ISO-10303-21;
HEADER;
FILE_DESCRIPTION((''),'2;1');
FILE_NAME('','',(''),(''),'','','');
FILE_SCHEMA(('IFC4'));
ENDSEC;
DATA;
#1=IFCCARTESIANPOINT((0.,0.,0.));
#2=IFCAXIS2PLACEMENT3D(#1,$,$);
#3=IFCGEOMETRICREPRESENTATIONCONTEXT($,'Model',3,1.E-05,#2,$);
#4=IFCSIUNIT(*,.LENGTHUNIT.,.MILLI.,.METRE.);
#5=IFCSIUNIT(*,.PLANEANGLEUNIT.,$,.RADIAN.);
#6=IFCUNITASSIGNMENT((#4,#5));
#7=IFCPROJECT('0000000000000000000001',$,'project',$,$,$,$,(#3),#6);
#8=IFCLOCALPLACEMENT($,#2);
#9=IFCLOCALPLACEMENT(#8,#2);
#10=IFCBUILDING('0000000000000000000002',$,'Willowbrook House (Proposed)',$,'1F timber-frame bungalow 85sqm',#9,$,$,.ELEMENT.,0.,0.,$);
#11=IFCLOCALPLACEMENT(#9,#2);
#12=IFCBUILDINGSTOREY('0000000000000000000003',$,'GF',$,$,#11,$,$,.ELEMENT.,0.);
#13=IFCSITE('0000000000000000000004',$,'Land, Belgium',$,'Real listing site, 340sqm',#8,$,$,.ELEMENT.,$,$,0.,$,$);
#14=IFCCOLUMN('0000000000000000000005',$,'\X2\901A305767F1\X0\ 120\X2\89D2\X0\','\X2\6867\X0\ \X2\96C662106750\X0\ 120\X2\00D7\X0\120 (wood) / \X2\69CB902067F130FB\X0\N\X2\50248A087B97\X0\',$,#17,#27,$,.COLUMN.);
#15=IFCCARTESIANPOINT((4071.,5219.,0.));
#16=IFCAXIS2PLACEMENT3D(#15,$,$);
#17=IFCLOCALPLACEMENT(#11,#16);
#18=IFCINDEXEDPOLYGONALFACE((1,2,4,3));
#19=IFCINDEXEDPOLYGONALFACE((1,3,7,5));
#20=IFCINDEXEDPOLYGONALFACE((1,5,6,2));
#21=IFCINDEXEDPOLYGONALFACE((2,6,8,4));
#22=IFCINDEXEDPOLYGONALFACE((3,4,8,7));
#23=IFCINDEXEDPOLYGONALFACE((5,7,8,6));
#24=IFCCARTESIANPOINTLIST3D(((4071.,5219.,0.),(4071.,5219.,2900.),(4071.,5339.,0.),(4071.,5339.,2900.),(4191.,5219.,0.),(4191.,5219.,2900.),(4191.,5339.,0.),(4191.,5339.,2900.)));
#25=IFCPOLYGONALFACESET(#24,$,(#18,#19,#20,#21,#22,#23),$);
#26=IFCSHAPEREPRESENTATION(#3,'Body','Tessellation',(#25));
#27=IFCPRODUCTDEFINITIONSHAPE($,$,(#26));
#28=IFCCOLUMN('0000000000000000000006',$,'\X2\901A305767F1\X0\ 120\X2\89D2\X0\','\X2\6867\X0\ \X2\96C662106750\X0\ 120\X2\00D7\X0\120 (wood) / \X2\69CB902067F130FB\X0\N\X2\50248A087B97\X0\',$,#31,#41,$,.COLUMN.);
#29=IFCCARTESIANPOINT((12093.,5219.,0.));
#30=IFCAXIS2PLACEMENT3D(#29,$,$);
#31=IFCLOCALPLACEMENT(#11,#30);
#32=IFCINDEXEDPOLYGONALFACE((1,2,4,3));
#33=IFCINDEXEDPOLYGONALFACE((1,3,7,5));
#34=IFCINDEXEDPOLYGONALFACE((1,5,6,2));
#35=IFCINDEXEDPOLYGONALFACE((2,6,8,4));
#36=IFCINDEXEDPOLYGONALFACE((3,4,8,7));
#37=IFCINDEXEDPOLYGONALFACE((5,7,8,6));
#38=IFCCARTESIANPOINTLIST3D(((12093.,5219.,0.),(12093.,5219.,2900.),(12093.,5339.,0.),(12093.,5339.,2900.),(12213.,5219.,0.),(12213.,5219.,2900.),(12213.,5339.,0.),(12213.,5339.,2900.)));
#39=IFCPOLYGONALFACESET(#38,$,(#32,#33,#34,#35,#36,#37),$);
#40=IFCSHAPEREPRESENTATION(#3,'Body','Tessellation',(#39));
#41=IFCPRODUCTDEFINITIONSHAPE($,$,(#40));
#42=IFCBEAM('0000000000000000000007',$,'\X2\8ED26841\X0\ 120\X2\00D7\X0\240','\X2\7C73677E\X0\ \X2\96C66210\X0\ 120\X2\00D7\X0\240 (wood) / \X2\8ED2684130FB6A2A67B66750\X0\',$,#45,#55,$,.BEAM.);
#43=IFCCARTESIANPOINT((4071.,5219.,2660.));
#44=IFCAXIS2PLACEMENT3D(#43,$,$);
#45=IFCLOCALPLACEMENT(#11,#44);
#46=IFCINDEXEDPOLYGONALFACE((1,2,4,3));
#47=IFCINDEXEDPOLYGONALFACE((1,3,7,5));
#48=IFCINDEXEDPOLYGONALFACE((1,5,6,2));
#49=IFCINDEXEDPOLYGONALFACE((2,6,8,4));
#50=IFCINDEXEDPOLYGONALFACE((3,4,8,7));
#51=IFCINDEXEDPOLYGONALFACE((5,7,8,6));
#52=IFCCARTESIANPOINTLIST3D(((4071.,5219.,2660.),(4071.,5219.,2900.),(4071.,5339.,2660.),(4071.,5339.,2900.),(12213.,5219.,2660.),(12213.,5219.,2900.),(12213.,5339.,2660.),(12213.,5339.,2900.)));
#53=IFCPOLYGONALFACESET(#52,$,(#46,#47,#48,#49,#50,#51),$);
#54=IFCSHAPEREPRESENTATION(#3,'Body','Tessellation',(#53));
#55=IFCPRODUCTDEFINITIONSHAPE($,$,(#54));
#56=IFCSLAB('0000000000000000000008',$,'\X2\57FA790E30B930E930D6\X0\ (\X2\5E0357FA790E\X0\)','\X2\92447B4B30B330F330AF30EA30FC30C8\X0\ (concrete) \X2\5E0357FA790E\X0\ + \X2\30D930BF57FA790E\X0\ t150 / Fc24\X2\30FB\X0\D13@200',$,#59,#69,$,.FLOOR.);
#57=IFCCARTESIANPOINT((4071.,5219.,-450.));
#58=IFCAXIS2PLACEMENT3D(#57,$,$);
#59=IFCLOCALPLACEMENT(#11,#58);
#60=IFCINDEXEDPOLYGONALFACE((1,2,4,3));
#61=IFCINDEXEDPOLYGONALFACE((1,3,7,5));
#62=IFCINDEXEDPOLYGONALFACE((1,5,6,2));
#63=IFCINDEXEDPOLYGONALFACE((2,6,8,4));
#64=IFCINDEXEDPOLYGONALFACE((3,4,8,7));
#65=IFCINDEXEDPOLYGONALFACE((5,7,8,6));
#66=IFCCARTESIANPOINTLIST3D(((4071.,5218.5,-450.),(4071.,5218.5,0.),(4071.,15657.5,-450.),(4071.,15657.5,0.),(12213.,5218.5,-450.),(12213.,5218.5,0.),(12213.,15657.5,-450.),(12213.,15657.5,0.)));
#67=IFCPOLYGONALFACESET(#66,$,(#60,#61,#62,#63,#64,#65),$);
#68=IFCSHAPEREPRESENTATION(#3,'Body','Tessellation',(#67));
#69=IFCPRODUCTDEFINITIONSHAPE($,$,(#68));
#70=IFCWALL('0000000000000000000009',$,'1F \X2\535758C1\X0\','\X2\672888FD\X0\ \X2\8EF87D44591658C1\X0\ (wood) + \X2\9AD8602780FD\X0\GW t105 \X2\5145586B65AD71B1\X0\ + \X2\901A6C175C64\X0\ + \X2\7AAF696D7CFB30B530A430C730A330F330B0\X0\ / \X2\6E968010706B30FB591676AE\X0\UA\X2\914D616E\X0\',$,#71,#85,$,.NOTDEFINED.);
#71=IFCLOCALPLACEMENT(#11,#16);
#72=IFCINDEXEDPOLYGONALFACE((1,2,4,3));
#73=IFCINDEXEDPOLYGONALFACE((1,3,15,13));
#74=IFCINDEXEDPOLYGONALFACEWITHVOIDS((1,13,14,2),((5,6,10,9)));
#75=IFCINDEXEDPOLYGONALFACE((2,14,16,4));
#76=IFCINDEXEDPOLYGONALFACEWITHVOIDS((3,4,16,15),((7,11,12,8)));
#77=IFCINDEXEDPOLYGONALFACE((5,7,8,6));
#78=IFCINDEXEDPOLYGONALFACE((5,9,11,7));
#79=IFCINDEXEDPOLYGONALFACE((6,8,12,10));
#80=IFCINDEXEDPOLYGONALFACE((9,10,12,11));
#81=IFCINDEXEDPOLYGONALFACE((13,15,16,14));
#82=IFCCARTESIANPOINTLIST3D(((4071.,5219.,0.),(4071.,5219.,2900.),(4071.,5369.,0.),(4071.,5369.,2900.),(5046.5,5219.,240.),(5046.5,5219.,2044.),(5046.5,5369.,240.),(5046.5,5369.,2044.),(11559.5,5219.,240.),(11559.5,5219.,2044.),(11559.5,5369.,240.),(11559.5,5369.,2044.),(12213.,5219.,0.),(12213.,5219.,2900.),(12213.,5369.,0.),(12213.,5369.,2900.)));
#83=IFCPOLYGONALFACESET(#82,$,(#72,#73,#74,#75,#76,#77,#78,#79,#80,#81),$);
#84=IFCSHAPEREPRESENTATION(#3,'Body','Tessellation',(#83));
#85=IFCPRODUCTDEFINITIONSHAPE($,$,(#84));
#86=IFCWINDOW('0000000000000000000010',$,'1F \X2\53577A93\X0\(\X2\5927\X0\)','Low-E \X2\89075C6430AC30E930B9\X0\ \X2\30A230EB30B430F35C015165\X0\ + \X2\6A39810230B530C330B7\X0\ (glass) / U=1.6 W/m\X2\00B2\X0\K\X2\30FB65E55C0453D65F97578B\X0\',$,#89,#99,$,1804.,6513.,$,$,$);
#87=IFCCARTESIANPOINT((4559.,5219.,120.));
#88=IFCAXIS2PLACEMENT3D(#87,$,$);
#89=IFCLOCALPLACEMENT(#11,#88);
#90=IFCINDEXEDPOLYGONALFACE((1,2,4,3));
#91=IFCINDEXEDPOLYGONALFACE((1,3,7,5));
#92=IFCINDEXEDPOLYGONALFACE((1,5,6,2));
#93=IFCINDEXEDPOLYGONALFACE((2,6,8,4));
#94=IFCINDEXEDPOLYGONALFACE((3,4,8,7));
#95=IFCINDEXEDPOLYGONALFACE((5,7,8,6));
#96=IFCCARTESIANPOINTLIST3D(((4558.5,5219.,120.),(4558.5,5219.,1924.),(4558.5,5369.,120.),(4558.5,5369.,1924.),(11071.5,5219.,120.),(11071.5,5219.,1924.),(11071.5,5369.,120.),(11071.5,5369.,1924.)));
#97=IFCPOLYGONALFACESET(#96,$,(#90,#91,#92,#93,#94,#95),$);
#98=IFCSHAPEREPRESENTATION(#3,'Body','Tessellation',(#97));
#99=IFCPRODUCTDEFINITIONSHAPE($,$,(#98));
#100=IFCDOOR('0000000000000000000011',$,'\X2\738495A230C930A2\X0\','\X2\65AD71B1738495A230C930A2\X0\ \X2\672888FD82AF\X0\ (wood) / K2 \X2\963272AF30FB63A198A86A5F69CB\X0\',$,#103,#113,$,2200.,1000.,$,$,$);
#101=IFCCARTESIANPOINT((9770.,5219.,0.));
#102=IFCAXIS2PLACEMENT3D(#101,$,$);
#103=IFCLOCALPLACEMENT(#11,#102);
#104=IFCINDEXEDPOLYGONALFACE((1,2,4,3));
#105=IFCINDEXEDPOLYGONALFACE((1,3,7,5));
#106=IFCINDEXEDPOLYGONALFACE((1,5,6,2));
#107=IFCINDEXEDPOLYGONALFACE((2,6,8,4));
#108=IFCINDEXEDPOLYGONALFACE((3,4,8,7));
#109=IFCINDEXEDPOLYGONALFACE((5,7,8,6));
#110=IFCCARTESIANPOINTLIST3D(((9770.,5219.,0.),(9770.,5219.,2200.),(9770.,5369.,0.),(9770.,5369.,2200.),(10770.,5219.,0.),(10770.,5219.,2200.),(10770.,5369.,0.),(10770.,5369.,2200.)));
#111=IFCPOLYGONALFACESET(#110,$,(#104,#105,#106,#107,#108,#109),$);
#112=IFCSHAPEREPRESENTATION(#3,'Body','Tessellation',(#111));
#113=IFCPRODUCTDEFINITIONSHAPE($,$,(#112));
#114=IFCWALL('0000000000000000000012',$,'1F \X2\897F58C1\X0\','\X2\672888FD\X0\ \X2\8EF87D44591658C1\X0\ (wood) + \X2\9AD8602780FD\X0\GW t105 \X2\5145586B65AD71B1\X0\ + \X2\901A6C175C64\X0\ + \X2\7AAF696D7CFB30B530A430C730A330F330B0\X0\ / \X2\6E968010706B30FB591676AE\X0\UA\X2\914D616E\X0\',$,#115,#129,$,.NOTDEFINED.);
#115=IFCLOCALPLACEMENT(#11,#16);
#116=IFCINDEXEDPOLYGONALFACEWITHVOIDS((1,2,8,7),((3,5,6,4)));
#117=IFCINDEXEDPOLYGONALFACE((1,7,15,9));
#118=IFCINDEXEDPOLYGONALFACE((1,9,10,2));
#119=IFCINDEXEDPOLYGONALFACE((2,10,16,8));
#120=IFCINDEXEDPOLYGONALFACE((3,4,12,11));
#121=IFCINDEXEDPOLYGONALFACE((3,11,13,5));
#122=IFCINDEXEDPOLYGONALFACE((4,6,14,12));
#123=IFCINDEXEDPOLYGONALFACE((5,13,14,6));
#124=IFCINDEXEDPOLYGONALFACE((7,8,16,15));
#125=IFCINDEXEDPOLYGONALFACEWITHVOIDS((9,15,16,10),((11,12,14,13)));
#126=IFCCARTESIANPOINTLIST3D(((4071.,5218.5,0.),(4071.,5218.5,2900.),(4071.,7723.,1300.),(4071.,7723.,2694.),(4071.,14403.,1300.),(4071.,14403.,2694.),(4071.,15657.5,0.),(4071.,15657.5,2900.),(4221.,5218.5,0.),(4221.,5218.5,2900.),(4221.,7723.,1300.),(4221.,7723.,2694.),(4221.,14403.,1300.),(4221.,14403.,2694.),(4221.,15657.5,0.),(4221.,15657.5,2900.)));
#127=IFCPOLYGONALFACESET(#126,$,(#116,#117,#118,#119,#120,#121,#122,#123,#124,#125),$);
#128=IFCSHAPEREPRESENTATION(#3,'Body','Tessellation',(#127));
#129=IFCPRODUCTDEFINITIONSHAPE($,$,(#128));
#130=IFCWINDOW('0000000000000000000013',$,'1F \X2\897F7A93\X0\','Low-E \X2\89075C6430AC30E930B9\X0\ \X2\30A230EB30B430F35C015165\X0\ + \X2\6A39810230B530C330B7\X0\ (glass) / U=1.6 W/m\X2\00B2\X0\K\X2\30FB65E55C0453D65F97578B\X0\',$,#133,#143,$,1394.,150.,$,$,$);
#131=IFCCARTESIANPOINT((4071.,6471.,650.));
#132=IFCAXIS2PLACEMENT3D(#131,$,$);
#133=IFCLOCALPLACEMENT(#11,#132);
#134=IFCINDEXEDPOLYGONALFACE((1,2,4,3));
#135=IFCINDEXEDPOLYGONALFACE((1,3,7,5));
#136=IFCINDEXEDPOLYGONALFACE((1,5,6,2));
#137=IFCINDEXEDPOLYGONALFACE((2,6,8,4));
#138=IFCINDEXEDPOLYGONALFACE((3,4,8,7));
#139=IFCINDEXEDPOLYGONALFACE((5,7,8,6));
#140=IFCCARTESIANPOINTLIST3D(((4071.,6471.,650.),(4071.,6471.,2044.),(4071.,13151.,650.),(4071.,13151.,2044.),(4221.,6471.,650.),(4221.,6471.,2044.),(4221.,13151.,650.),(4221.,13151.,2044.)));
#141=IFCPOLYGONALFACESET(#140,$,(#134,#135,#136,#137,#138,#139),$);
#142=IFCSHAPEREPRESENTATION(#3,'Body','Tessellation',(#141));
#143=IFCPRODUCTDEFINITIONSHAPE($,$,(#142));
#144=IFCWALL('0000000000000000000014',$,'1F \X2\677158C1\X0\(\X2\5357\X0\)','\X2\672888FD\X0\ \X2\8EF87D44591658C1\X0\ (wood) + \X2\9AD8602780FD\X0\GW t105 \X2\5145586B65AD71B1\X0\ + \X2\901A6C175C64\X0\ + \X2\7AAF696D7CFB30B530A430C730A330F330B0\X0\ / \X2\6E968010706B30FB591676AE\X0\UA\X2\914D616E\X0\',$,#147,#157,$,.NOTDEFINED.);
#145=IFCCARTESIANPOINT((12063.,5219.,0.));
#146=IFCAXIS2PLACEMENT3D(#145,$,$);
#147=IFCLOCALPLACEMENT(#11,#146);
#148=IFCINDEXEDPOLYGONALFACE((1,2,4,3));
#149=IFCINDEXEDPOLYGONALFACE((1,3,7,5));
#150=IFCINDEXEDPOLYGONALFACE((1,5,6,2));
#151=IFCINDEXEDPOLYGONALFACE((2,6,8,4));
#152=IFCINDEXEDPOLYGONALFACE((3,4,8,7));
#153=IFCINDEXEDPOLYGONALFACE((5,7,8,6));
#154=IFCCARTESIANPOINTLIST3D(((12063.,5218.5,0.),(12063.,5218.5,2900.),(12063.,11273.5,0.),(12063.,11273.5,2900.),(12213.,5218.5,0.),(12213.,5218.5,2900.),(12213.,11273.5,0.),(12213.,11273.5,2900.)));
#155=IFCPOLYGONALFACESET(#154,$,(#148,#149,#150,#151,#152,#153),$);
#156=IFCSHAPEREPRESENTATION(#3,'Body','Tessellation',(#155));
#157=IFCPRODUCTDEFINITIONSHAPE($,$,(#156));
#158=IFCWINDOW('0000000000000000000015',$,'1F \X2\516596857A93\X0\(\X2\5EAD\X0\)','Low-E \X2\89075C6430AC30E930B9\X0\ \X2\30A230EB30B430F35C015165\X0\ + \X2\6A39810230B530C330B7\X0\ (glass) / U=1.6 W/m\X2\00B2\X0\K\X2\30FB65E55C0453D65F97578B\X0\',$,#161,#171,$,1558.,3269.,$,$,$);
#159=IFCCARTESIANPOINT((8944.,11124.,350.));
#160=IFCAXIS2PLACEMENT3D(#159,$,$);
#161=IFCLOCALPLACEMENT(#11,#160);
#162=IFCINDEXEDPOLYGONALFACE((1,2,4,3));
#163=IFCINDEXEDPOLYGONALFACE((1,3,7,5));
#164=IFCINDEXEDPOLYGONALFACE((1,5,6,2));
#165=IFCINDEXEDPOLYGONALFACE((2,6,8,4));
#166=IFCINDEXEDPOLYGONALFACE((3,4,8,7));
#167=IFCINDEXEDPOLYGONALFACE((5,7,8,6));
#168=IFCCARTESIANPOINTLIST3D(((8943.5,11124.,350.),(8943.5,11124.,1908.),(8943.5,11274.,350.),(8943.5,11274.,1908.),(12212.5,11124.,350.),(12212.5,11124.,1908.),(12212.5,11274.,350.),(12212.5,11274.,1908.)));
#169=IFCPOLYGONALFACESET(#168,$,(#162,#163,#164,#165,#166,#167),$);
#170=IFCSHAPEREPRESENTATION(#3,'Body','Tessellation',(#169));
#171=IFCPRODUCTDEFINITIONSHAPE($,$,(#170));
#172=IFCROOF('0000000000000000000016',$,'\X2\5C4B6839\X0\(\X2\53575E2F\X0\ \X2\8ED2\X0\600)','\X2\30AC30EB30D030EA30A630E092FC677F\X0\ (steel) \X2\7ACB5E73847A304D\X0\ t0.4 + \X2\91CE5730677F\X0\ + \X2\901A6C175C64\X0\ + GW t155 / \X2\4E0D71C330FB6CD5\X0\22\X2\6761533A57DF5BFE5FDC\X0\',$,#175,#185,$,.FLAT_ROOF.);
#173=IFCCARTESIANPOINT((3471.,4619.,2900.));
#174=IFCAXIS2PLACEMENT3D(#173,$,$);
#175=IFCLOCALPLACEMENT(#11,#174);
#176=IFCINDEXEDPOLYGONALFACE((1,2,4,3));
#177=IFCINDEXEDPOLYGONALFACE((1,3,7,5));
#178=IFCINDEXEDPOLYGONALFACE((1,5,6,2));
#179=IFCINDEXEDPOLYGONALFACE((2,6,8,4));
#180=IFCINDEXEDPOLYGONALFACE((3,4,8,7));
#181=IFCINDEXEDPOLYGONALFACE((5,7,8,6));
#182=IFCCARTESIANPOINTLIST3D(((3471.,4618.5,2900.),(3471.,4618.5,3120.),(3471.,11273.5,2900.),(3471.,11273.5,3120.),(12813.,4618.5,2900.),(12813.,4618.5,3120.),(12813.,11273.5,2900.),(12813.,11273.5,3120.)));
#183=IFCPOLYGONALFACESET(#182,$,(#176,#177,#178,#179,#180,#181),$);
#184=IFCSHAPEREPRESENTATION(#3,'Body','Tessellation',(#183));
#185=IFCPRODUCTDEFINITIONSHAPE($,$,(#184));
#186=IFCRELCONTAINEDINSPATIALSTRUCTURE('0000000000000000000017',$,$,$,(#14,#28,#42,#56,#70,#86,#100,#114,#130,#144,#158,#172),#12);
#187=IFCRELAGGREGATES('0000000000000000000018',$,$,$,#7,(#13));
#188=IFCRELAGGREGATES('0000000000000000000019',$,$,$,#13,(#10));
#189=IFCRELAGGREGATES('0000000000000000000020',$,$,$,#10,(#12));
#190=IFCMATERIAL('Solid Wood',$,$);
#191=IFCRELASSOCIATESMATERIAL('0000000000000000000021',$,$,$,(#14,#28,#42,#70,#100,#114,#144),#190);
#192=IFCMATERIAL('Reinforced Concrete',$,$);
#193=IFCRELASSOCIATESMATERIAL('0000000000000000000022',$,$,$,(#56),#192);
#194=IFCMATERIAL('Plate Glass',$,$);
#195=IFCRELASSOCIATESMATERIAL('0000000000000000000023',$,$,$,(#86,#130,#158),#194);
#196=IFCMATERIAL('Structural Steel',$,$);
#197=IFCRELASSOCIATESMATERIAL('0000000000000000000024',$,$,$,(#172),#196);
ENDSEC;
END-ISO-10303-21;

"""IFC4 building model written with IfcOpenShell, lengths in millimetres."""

from ifc_helpers import new_model, si_unit, frame, frame_2d, origin, place, context, project, spatial, rectangle, extrude, material, element, fill, save


model = new_model("IFC4")

# Units and contexts
model_context = context("Model", 3, precision=1e-05, world=origin())
ifc_project = project(units=[si_unit("LENGTHUNIT", "METRE", prefix="MILLI"), si_unit("PLANEANGLEUNIT", "RADIAN")], contexts=[model_context])

# Site, building, storey
site_placement = place(None, origin())
site = spatial("IfcSite", under=ifc_project, at=site_placement, Name="Land, Belgium", ObjectType="Real listing site, 340sqm", CompositionType="ELEMENT", RefElevation=0.0)
building_placement = place(site_placement, origin())
building = spatial("IfcBuilding", under=site, at=building_placement, Name="Willowbrook House (Proposed)", ObjectType="1F timber-frame bungalow 85sqm", CompositionType="ELEMENT", ElevationOfRefHeight=0.0, ElevationOfTerrain=0.0)
storey_placement = place(building_placement, origin())
storey = spatial("IfcBuildingStorey", under=building, at=storey_placement, Name="GF", CompositionType="ELEMENT", Elevation=0.0)

# Columns
ifc_material_1 = material(Name="Solid Wood")
column_1_placement = place(storey_placement, frame((4071.0, 5219.0, 0.0)))
element("IfcColumn", 1, at=column_1_placement, inside=storey, material=ifc_material_1, Name="通し柱 120角", Description="桧 集成材 120×120 (wood) / 構造柱・N値計算", PredefinedType="COLUMN", context=model_context, shape_type="SweptSolid", body=[
    extrude(rectangle(XDim=120.0, YDim=120.0, at=frame_2d((60.0, 60.0))), frame((4071.0, 5219.0, 0.0)), (0.0, 0.0, 1.0), 2900.0),
])
column_2_placement = place(storey_placement, frame((12093.0, 5219.0, 0.0)))
element("IfcColumn", 2, at=column_2_placement, inside=storey, material=ifc_material_1, Name="通し柱 120角", Description="桧 集成材 120×120 (wood) / 構造柱・N値計算", PredefinedType="COLUMN", context=model_context, shape_type="SweptSolid", body=[
    extrude(rectangle(XDim=120.0, YDim=120.0, at=frame_2d((60.0, 60.0))), frame((12093.0, 5219.0, 0.0)), (0.0, 0.0, 1.0), 2900.0),
])

# Beam
beam_1_placement = place(storey_placement, frame((4071.0, 5219.0, 2660.0)))
element("IfcBeam", 3, at=beam_1_placement, inside=storey, material=ifc_material_1, Name="軒桁 120×240", Description="米松 集成 120×240 (wood) / 軒桁・横架材", PredefinedType="BEAM", context=model_context, shape_type="SweptSolid", body=[
    extrude(rectangle(XDim=8142.0, YDim=120.0, at=frame_2d((4071.0, 60.0))), frame((4071.0, 5219.0, 2660.0)), (0.0, 0.0, 1.0), 240.0),
])

# Slab
ifc_material_2 = material(Name="Reinforced Concrete")
slab_1_placement = place(storey_placement, frame((4071.0, 5219.0, -450.0)))
element("IfcSlab", 4, at=slab_1_placement, inside=storey, material=ifc_material_2, Name="基礎スラブ (布基礎)", Description="鉄筋コンクリート (concrete) 布基礎 + ベタ基礎 t150 / Fc24・D13@200", PredefinedType="FLOOR", context=model_context, shape_type="SweptSolid", body=[
    extrude(rectangle(XDim=8142.0, YDim=10439.0, at=frame_2d((4071.0, 5219.0))), frame((4071.0, 5219.0, -450.0)), (0.0, 0.0, 1.0), 450.0),
])

# Wall, openings, window, door
wall_1_placement = place(storey_placement, frame((4071.0, 5219.0, 0.0)))
wall_1 = element("IfcWall", 5, at=wall_1_placement, inside=storey, material=ifc_material_1, Name="1F 南壁", Description="木製 軸組外壁 (wood) + 高性能GW t105 充填断熱 + 通気層 + 窯業系サイディング / 準耐火・外皮UA配慮", PredefinedType="NOTDEFINED", context=model_context, shape_type="SweptSolid", body=[
    extrude(rectangle(XDim=8142.0, YDim=150.0, at=frame_2d((4071.0, 75.0))), frame((4071.0, 5219.0, 0.0)), (0.0, 0.0, 1.0), 2900.0),
])
opening_1_placement = place(storey_placement, frame((4559.0, 5219.0, 120.0)))
opening_1 = element("IfcOpeningElement", 6, at=opening_1_placement, cuts=wall_1, PredefinedType="NOTDEFINED", context=model_context, shape_type="SweptSolid", body=[
    extrude(rectangle(XDim=6513.0, YDim=150.0, at=frame_2d((3256.0, 75.0))), frame((4559.0, 5219.0, 120.0)), (0.0, 0.0, 1.0), 1804.0),
])
opening_2_placement = place(storey_placement, frame((9770.0, 5219.0, 0.0)))
opening_2 = element("IfcOpeningElement", 7, at=opening_2_placement, cuts=wall_1, PredefinedType="NOTDEFINED", context=model_context, shape_type="SweptSolid", body=[
    extrude(rectangle(XDim=1000.0, YDim=150.0, at=frame_2d((500.0, 75.0))), frame((9770.0, 5219.0, 0.0)), (0.0, 0.0, 1.0), 2200.0),
])
ifc_material_3 = material(Name="Plate Glass")
window_1_placement = place(storey_placement, frame((4559.0, 5219.0, 120.0)))
window_1 = element("IfcWindow", 8, at=window_1_placement, inside=storey, material=ifc_material_3, Name="1F 南窓(大)", Description="Low-E 複層ガラス アルゴン封入 + 樹脂サッシ (glass) / U=1.6 W/m²K・日射取得型", OverallHeight=1804.0, OverallWidth=6513.0, context=model_context, shape_type="SweptSolid", body=[
    extrude(rectangle(XDim=6513.0, YDim=150.0, at=frame_2d((3256.0, 75.0))), frame((4559.0, 5219.0, 120.0)), (0.0, 0.0, 1.0), 1804.0),
])
fill(opening_1, window_1)
door_1_placement = place(storey_placement, frame((9770.0, 5219.0, 0.0)))
door_1 = element("IfcDoor", 9, at=door_1_placement, inside=storey, material=ifc_material_1, Name="玄関ドア", Description="断熱玄関ドア 木製芯 (wood) / K2 防犯・採風機構", OverallHeight=2200.0, OverallWidth=1000.0, context=model_context, shape_type="SweptSolid", body=[
    extrude(rectangle(XDim=1000.0, YDim=150.0, at=frame_2d((500.0, 75.0))), frame((9770.0, 5219.0, 0.0)), (0.0, 0.0, 1.0), 2200.0),
])
fill(opening_2, door_1)

# Walls, openings, windows
wall_2_placement = place(storey_placement, frame((4071.0, 5219.0, 0.0)))
wall_2 = element("IfcWall", 10, at=wall_2_placement, inside=storey, material=ifc_material_1, Name="1F 西壁", Description="木製 軸組外壁 (wood) + 高性能GW t105 充填断熱 + 通気層 + 窯業系サイディング / 準耐火・外皮UA配慮", PredefinedType="NOTDEFINED", context=model_context, shape_type="SweptSolid", body=[
    extrude(rectangle(XDim=150.0, YDim=10439.0, at=frame_2d((75.0, 5219.0))), frame((4071.0, 5219.0, 0.0)), (0.0, 0.0, 1.0), 2900.0),
])
opening_3_placement = place(storey_placement, frame((4071.0, 6471.0, 650.0)))
opening_3 = element("IfcOpeningElement", 11, at=opening_3_placement, cuts=wall_2, PredefinedType="NOTDEFINED", context=model_context, shape_type="SweptSolid", body=[
    extrude(rectangle(XDim=150.0, YDim=6680.0, at=frame_2d((75.0, 3340.0))), frame((4071.0, 6471.0, 650.0)), (0.0, 0.0, 1.0), 1394.0),
])
window_2_placement = place(storey_placement, frame((4071.0, 6471.0, 650.0)))
window_2 = element("IfcWindow", 12, at=window_2_placement, inside=storey, material=ifc_material_3, Name="1F 西窓", Description="Low-E 複層ガラス アルゴン封入 + 樹脂サッシ (glass) / U=1.6 W/m²K・日射取得型", OverallHeight=1394.0, OverallWidth=150.0, context=model_context, shape_type="SweptSolid", body=[
    extrude(rectangle(XDim=150.0, YDim=6680.0, at=frame_2d((75.0, 3340.0))), frame((4071.0, 6471.0, 650.0)), (0.0, 0.0, 1.0), 1394.0),
])
fill(opening_3, window_2)
wall_3_placement = place(storey_placement, frame((12063.0, 5219.0, 0.0)))
wall_3 = element("IfcWall", 13, at=wall_3_placement, inside=storey, material=ifc_material_1, Name="1F 東壁(南)", Description="木製 軸組外壁 (wood) + 高性能GW t105 充填断熱 + 通気層 + 窯業系サイディング / 準耐火・外皮UA配慮", PredefinedType="NOTDEFINED", context=model_context, shape_type="SweptSolid", body=[
    extrude(rectangle(XDim=150.0, YDim=6055.0, at=frame_2d((75.0, 3027.0))), frame((12063.0, 5219.0, 0.0)), (0.0, 0.0, 1.0), 2900.0),
])
opening_4_placement = place(storey_placement, frame((8944.0, 11124.0, 350.0)))
opening_4 = element("IfcOpeningElement", 14, at=opening_4_placement, cuts=wall_3, PredefinedType="NOTDEFINED", context=model_context, shape_type="SweptSolid", body=[
    extrude(rectangle(XDim=3269.0, YDim=150.0, at=frame_2d((1634.0, 75.0))), frame((8944.0, 11124.0, 350.0)), (0.0, 0.0, 1.0), 1558.0),
])
window_3_placement = place(storey_placement, frame((8944.0, 11124.0, 350.0)))
window_3 = element("IfcWindow", 15, at=window_3_placement, inside=storey, material=ifc_material_3, Name="1F 入隅窓(庭)", Description="Low-E 複層ガラス アルゴン封入 + 樹脂サッシ (glass) / U=1.6 W/m²K・日射取得型", OverallHeight=1558.0, OverallWidth=3269.0, context=model_context, shape_type="SweptSolid", body=[
    extrude(rectangle(XDim=3269.0, YDim=150.0, at=frame_2d((1634.0, 75.0))), frame((8944.0, 11124.0, 350.0)), (0.0, 0.0, 1.0), 1558.0),
])
fill(opening_4, window_3)

# Roof
ifc_material_4 = material(Name="Structural Steel")
roof_placement = place(storey_placement, frame((3471.0, 4619.0, 2900.0)))
element("IfcRoof", 16, at=roof_placement, inside=storey, material=ifc_material_4, Name="屋根(南帯 軒600)", Description="ガルバリウム鋼板 (steel) 立平葺き t0.4 + 野地板 + 通気層 + GW t155 / 不燃・法22条区域対応", PredefinedType="FLAT_ROOF", context=model_context, shape_type="SweptSolid", body=[
    extrude(rectangle(XDim=9342.0, YDim=6655.0, at=frame_2d((4671.0, 3327.0))), frame((3471.0, 4619.0, 2900.0)), (0.0, 0.0, 1.0), 220.0),
])

save(model, "model.ifc")
